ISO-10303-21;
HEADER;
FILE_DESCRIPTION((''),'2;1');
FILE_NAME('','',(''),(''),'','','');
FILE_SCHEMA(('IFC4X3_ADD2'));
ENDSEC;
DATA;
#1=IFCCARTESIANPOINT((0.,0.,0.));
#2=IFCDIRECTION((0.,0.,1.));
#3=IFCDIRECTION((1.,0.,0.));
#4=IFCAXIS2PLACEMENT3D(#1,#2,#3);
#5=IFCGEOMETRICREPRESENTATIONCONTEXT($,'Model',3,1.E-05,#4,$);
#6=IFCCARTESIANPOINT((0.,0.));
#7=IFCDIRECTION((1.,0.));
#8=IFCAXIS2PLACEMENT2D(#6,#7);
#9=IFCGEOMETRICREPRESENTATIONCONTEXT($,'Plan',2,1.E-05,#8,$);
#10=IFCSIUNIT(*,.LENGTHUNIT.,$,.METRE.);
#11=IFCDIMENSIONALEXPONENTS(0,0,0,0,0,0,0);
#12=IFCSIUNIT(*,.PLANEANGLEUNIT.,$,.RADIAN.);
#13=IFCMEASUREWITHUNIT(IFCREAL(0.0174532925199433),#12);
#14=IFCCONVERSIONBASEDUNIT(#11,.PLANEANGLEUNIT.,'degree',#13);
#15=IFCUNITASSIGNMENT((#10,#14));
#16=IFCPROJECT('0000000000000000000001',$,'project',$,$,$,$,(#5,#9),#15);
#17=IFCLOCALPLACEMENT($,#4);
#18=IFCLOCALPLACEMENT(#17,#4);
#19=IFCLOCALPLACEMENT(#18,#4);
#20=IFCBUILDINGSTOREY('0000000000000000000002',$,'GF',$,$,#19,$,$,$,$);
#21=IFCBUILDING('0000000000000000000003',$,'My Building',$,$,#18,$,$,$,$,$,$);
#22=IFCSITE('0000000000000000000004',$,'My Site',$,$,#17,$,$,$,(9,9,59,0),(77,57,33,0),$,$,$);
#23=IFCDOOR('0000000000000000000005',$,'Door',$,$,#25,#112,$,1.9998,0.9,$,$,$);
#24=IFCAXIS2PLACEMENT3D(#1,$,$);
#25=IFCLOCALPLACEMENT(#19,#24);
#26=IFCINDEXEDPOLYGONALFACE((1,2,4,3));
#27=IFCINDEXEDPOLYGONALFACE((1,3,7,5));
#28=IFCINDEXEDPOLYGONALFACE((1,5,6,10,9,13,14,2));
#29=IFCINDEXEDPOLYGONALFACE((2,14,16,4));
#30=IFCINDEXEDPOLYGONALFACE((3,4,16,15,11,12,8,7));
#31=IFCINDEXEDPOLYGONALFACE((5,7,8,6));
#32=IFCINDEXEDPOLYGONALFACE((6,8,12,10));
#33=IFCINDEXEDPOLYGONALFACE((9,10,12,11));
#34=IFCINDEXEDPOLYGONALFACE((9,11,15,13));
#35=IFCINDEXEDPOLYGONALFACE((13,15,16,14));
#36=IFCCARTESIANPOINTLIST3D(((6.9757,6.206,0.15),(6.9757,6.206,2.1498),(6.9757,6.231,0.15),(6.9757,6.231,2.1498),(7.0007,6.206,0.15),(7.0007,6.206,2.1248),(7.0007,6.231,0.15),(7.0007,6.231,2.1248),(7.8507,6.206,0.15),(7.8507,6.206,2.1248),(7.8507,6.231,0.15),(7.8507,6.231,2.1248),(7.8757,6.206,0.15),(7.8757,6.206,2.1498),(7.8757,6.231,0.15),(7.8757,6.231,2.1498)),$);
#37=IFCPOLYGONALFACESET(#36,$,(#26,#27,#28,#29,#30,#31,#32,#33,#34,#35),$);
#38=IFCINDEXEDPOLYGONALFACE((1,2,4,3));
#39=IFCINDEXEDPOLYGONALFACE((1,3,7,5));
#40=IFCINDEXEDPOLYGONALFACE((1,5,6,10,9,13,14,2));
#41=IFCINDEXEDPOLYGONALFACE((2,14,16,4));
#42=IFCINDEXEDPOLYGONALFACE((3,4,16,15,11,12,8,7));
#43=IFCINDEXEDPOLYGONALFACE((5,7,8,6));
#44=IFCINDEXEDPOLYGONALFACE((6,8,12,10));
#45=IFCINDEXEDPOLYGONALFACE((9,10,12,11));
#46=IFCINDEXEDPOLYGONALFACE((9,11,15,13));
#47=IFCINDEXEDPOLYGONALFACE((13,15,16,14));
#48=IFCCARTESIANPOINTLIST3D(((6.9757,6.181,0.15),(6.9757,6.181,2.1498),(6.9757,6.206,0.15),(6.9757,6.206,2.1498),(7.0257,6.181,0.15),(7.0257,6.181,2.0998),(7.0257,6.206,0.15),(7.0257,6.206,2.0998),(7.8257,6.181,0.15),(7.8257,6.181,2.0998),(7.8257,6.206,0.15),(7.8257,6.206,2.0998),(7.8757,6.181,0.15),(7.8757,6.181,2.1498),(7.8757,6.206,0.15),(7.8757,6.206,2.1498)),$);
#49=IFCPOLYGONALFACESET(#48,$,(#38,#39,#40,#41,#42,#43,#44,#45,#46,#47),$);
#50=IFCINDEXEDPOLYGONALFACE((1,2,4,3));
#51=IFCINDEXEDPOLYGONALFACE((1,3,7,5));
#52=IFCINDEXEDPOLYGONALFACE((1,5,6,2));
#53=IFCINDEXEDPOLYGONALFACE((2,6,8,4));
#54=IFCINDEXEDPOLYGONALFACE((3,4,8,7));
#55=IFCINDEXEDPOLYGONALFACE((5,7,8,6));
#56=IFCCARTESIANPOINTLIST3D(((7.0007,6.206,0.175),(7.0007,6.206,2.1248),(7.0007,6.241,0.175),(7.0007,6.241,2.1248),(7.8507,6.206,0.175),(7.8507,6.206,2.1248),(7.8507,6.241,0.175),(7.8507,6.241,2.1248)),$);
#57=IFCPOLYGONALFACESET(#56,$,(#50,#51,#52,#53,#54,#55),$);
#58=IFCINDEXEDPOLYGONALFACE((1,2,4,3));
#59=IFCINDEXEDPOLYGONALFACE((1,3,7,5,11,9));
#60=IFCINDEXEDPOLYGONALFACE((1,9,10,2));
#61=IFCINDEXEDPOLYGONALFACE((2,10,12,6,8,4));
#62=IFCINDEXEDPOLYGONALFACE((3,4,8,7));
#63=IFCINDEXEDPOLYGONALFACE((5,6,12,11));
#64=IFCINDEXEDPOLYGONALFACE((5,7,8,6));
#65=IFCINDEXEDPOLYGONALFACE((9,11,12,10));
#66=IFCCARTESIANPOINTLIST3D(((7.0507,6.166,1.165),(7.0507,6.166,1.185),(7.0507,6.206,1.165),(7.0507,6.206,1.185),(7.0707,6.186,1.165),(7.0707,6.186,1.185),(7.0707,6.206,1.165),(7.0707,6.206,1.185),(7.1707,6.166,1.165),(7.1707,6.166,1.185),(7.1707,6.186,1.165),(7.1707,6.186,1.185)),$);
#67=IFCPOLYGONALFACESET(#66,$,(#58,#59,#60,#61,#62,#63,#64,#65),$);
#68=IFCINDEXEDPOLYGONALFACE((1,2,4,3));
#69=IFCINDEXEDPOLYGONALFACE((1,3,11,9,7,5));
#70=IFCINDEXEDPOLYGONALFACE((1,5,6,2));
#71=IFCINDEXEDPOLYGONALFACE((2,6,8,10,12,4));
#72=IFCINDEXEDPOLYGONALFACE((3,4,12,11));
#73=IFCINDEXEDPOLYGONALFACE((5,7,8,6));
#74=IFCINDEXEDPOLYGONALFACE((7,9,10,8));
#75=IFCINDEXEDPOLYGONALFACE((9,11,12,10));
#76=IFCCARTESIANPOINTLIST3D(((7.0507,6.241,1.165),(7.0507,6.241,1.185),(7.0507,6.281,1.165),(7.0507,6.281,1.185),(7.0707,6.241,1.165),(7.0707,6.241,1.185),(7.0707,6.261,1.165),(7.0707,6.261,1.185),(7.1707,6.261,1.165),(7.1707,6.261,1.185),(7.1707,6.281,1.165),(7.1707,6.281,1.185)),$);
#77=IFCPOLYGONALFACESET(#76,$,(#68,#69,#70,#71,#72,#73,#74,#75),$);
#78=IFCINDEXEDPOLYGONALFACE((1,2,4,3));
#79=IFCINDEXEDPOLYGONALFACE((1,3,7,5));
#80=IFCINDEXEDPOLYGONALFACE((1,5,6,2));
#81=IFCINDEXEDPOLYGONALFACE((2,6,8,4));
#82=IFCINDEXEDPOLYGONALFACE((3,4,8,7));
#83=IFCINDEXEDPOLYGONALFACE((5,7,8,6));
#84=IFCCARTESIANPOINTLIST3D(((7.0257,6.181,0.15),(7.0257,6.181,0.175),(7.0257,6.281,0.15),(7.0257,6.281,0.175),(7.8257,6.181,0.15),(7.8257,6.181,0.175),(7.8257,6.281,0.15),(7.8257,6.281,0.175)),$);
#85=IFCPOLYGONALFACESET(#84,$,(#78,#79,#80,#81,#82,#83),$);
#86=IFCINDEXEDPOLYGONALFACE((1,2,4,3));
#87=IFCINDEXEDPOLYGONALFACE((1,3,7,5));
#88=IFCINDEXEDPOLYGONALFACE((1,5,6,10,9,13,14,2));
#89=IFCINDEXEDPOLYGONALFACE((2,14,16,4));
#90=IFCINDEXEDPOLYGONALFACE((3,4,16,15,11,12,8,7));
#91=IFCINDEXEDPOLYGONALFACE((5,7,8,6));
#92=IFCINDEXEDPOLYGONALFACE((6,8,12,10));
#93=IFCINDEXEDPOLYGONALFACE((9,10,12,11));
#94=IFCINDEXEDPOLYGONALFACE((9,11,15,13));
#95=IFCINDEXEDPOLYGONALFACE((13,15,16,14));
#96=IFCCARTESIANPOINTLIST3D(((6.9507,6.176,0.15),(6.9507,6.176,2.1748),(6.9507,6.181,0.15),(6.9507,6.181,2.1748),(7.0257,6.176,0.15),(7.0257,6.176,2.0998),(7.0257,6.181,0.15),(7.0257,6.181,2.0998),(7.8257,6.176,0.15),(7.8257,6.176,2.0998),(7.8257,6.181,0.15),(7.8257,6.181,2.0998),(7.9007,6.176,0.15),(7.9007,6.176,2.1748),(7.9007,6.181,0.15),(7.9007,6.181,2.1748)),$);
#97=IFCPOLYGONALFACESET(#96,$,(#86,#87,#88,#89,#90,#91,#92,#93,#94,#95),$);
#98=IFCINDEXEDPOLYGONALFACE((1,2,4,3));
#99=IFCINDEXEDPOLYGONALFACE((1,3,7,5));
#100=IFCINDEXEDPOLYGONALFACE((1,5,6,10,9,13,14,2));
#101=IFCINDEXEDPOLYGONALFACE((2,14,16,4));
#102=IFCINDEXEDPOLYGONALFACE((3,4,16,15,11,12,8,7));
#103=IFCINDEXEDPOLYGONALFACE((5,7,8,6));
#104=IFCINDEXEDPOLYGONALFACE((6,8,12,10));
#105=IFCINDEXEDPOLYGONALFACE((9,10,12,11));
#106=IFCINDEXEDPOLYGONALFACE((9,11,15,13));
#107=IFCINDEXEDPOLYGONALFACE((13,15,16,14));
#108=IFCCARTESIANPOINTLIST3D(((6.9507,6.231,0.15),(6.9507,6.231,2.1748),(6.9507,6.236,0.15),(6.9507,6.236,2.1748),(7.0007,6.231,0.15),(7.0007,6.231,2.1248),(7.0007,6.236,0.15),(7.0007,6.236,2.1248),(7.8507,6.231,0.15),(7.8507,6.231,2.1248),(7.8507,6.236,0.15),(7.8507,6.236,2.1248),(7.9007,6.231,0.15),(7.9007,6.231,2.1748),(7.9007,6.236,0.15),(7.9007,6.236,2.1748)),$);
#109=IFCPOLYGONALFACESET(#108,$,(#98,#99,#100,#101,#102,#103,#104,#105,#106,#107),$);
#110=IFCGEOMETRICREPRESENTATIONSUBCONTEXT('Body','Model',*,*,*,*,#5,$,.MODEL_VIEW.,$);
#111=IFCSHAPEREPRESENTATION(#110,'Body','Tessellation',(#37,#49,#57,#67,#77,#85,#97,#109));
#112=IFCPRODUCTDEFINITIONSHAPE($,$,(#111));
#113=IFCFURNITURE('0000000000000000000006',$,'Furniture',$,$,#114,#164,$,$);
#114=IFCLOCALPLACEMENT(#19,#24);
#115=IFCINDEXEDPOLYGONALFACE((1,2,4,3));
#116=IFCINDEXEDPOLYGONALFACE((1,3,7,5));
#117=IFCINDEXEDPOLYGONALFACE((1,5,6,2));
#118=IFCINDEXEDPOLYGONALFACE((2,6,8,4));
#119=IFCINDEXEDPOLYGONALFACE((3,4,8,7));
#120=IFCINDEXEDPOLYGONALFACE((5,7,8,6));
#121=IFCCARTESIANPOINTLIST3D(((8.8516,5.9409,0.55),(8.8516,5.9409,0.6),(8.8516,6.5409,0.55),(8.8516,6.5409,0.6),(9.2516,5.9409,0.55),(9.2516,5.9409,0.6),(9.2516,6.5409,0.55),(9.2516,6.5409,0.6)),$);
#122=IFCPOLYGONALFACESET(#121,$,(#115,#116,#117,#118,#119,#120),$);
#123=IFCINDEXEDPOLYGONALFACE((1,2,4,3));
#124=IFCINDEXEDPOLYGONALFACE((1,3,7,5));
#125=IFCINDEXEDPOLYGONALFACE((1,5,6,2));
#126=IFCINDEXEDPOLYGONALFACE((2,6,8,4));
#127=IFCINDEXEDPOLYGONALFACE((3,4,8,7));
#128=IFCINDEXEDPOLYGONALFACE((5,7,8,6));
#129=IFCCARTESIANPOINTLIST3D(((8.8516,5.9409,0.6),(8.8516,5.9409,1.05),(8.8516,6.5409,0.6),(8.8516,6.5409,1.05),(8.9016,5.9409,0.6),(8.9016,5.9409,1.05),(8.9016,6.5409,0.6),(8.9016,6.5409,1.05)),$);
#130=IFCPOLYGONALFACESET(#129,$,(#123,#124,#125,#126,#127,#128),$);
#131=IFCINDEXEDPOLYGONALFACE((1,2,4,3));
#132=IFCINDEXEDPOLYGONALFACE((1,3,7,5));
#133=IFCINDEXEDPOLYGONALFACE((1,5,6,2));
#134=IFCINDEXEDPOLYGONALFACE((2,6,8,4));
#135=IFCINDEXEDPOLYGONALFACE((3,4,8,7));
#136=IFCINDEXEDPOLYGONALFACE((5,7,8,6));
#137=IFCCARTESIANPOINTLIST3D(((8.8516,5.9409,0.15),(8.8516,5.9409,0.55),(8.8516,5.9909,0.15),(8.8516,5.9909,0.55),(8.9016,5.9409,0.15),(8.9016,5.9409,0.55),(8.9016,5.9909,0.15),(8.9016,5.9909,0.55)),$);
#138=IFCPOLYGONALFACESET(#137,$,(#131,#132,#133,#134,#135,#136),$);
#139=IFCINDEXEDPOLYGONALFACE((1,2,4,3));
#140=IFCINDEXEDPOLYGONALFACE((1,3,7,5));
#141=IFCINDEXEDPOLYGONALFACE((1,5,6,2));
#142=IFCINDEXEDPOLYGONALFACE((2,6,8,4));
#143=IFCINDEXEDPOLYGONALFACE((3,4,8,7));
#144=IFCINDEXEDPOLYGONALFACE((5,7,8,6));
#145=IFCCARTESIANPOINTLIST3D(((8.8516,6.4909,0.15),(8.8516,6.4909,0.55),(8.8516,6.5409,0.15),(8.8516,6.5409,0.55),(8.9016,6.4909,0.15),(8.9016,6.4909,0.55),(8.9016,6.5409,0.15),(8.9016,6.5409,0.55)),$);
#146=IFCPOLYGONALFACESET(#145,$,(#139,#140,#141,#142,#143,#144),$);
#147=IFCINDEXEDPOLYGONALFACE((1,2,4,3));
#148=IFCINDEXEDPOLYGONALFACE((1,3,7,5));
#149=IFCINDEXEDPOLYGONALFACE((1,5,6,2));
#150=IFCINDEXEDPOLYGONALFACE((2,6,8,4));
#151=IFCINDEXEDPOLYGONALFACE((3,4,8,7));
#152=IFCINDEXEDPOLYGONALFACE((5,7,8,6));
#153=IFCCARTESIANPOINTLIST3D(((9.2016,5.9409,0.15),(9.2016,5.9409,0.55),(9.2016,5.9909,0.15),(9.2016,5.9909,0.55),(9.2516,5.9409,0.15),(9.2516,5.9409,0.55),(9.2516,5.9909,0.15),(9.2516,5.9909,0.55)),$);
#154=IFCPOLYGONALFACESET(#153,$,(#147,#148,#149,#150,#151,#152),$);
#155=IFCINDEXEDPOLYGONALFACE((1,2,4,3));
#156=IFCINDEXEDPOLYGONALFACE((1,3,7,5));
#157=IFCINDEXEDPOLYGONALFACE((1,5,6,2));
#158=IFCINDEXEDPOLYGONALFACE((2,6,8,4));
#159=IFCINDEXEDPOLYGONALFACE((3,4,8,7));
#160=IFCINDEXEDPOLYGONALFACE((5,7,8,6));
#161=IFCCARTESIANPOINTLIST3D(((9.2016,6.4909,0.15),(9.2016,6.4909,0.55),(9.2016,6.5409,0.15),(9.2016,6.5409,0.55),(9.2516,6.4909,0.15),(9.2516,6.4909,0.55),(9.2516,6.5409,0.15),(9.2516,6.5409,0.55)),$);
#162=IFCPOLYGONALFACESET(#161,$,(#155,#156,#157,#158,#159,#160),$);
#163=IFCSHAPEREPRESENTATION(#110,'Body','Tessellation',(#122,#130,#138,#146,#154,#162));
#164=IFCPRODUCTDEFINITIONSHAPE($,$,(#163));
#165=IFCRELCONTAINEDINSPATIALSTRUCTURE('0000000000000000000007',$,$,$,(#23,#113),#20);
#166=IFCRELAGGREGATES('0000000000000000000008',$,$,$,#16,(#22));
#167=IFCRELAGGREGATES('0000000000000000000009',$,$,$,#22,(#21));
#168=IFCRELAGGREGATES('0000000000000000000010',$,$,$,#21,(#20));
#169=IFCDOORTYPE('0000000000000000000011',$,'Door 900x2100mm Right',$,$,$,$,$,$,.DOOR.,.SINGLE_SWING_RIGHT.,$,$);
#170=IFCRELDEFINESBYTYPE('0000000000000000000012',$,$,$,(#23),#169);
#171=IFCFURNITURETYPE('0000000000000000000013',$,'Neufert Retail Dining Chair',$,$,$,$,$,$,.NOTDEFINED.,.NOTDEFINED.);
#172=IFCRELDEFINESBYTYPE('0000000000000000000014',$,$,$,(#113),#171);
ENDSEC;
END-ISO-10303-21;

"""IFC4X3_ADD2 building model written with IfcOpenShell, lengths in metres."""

from ifc_helpers import new_model, entity, si_unit, converted_unit, frame, origin_with_axes, origin_2d_with_axis, place, context, subcontext, project, spatial, line, indexed_curve, outline, extrude, shape, source, transform, mapped, type_object, type_shapes, element, save


model = new_model("IFC4X3_ADD2")

# Units and contexts
model_context = context("Model", 3, precision=1e-05, world=origin_with_axes())
plan_context = context("Plan", 2, precision=1e-05, world=origin_2d_with_axis())
body_context_1 = subcontext(model_context, "Body", "Model", "MODEL_VIEW")
body_context_2 = subcontext(plan_context, "Body", "Plan", "PLAN_VIEW")
ifc_project = project(units=[si_unit("LENGTHUNIT", "METRE"), converted_unit("PLANEANGLEUNIT", "degree", entity("IfcReal", 0.0174532925199433), si_unit("PLANEANGLEUNIT", "RADIAN"), dimensions=[0, 0, 0, 0, 0, 0, 0])], contexts=[model_context, plan_context])

# Site, building, storey
site_placement = place(None, origin_with_axes())
site = spatial("IfcSite", under=ifc_project, at=site_placement, Name="My Site", RefLatitude=(9, 9, 59, 0), RefLongitude=(77, 57, 33, 0))
building_placement = place(site_placement, origin_with_axes())
building = spatial("IfcBuilding", under=site, at=building_placement, Name="My Building")
storey_placement = place(building_placement, origin_with_axes())
storey = spatial("IfcBuildingStorey", under=building, at=storey_placement, Name="GF")

# Shared definitions
door_type = type_object("IfcDoorType", Name="Door 900x2100mm Right", OperationType="SINGLE_SWING_RIGHT", PredefinedType="DOOR")
shared_shape_1 = source(origin_with_axes(), body_context_1, "Body", "SweptSolid", [
    extrude(outline(indexed_curve([(0.0, 0.0), (0.0, 1.9998), (0.9, 1.9998), (0.9, 0.0), (0.875, 0.0), (0.875, 1.9748), (0.025, 1.9748), (0.025, 0.0)], segments=[line(1, 2, 3, 4, 5, 6, 7, 8, 1)])), frame((0.0, 0.025, 0.0), z_axis=(0.0, -1.0, 0.0), x_axis=(1.0, 0.0, 0.0)), (0.0, 0.0, -1.0), 0.025),
    extrude(outline(indexed_curve([(0.0, 0.0), (0.0, 1.9998), (0.9, 1.9998), (0.9, 0.0), (0.85, 0.0), (0.85, 1.9498), (0.05, 1.9498), (0.05, 0.0)], segments=[line(1, 2, 3, 4, 5, 6, 7, 8, 1)])), frame((0.0, 0.0, 0.0), z_axis=(0.0, -1.0, 0.0), x_axis=(1.0, 0.0, 0.0)), (0.0, 0.0, -1.0), 0.025),
    extrude(outline(indexed_curve([(0.0, 0.0), (0.85, 0.0), (0.85, 0.035), (0.0, 0.035)], segments=[line(1, 2, 3, 4, 1)])), frame((0.025, 0.025, 0.025), z_axis=(0.0, 0.0, 1.0), x_axis=(1.0, 0.0, 0.0)), (0.0, 0.0, 1.0), 1.9498),
    extrude(outline(indexed_curve([(0.0, 0.0), (0.0, -0.04), (0.12, -0.04), (0.12, -0.02), (0.02, -0.02), (0.02, 0.0)], segments=[line(1, 2, 3, 4, 5, 6, 1)])), frame((0.075, 0.025, 1.015), z_axis=(0.0, 0.0, 1.0), x_axis=(1.0, 0.0, 0.0)), (0.0, 0.0, 1.0), 0.02),
    extrude(outline(indexed_curve([(0.0, 0.0), (0.0, 0.04), (0.12, 0.04), (0.12, 0.02), (0.02, 0.02), (0.02, 0.0)], segments=[line(1, 2, 3, 4, 5, 6, 1)])), frame((0.075, 0.06, 1.015), z_axis=(0.0, 0.0, 1.0), x_axis=(1.0, 0.0, 0.0)), (0.0, 0.0, 1.0), 0.02),
    extrude(outline(indexed_curve([(0.0, 0.0), (0.8, 0.0), (0.8, 0.1), (0.0, 0.1)], segments=[line(1, 2, 3, 4, 1)])), frame((0.05, 0.0, 0.0), z_axis=(0.0, 0.0, 1.0), x_axis=(1.0, 0.0, 0.0)), (0.0, 0.0, 1.0), 0.025),
    extrude(outline(indexed_curve([(0.0, 0.0), (0.0, 2.0248), (0.95, 2.0248), (0.95, 0.0), (0.875, 0.0), (0.875, 1.9498), (0.075, 1.9498), (0.075, 0.0)], segments=[line(1, 2, 3, 4, 5, 6, 7, 8, 1)])), frame((-0.025, -0.005, 0.0), z_axis=(0.0, -1.0, 0.0), x_axis=(1.0, 0.0, 0.0)), (0.0, 0.0, -1.0), 0.005),
    extrude(outline(indexed_curve([(0.0, 0.0), (0.0, 2.0248), (0.95, 2.0248), (0.95, 0.0), (0.9, 0.0), (0.9, 1.9748), (0.05, 1.9748), (0.05, 0.0)], segments=[line(1, 2, 3, 4, 5, 6, 7, 8, 1)])), frame((-0.025, 0.05, 0.0), z_axis=(0.0, -1.0, 0.0), x_axis=(1.0, 0.0, 0.0)), (0.0, 0.0, -1.0), 0.005),
])
shared_shape_2 = source(origin_with_axes(), body_context_2, "Body", "Curve2D", [
    entity("IfcIndexedPolyCurve", entity("IfcCartesianPointList2D", [[0.0, 0.0], [0.0, 0.05], [0.025, 0.05], [0.025, 0.025], [0.05, 0.025], [0.05, 0.0]]), [entity("IfcLineIndex", [1, 2, 3, 4, 5, 6, 1])]),
    entity("IfcIndexedPolyCurve", entity("IfcCartesianPointList2D", [[0.9, 0.0], [0.9, 0.05], [0.875, 0.05], [0.875, 0.025], [0.85, 0.025], [0.85, 0.0]]), [entity("IfcLineIndex", [1, 2, 3, 4, 5, 6, 1])]),
    entity("IfcTrimmedCurve", entity("IfcEllipse", entity("IfcAxis2Placement2D", entity("IfcCartesianPoint", [0.84, 0.05]), entity("IfcDirection", [1.0, 0.0])), 0.815, 0.85), [entity("IfcCartesianPoint", [0.84, 0.9])], [entity("IfcCartesianPoint", [0.025, 0.05])], True, "CARTESIAN"),
    entity("IfcIndexedPolyCurve", entity("IfcCartesianPointList2D", [[0.875, 0.05], [0.84, 0.05], [0.84, 0.9], [0.875, 0.9]]), [entity("IfcLineIndex", [1, 2, 3, 4, 1])]),
])
type_shapes(door_type, [shared_shape_1, shared_shape_2])

# Door
door_1_placement = place(storey_placement, frame((6.9757, 6.181, 0.15), z_axis=(0.0, 0.0, 1.0), x_axis=(1.0, -0.000001, 0.0)))
element("IfcDoor", 1, at=door_1_placement, inside=storey, type_object=door_type, Name="Door", OverallHeight=1.9998, OverallWidth=0.9, shapes=[
    shape(body_context_1, "Body", "MappedRepresentation", [mapped(shared_shape_1, transform((0.0, 0.0, 0.0), x_axis=(1.0, 0.0, 0.0), y_axis=(0.0, 1.0, 0.0), z_axis=(0.0, 0.0, 1.0), scale=1.0))]),
    shape(body_context_2, "Body", "MappedRepresentation", [mapped(shared_shape_2, transform((0.0, 0.0, 0.0), x_axis=(1.0, 0.0, 0.0), y_axis=(0.0, 1.0, 0.0), z_axis=(0.0, 0.0, 1.0), scale=1.0))]),
])

# Furniture
furniture_type_1 = type_object("IfcFurnitureType", Name="Neufert Retail Dining Chair", AssemblyPlace="NOTDEFINED", PredefinedType="NOTDEFINED")
shared_shape_3 = source(origin_with_axes(), body_context_1, "Body", "SweptSolid", [
    extrude(outline(indexed_curve([(-0.3, 0.0), (0.3, 0.0), (0.3, -0.4), (-0.3, -0.4)], segments=[line(1, 2, 3, 4, 1)])), frame((0.0, 0.0, 0.45), z_axis=(0.0, 0.0, 1.0), x_axis=(1.0, 0.0, 0.0)), (0.0, 0.0, -1.0), 0.05),
    extrude(outline(indexed_curve([(-0.3, 0.0), (0.3, 0.0), (0.3, -0.05), (-0.3, -0.05)], segments=[line(1, 2, 3, 4, 1)])), frame((0.0, 0.0, 0.9), z_axis=(0.0, 0.0, 1.0), x_axis=(1.0, 0.0, 0.0)), (0.0, 0.0, -1.0), 0.45),
    extrude(outline(indexed_curve([(-0.3, 0.0), (-0.25, 0.0), (-0.25, -0.05), (-0.3, -0.05)], segments=[line(1, 2, 3, 4, 1)])), origin_with_axes(), (0.0, 0.0, 1.0), 0.4),
    extrude(outline(indexed_curve([(0.3, 0.0), (0.25, 0.0), (0.25, -0.05), (0.3, -0.05)], segments=[line(1, 2, 3, 4, 1)])), origin_with_axes(), (0.0, 0.0, 1.0), 0.4),
    extrude(outline(indexed_curve([(-0.3, -0.4), (-0.25, -0.4), (-0.25, -0.35), (-0.3, -0.35)], segments=[line(1, 2, 3, 4, 1)])), origin_with_axes(), (0.0, 0.0, 1.0), 0.4),
    extrude(outline(indexed_curve([(0.3, -0.4), (0.25, -0.4), (0.25, -0.35), (0.3, -0.35)], segments=[line(1, 2, 3, 4, 1)])), origin_with_axes(), (0.0, 0.0, 1.0), 0.4),
])
shared_shape_4 = source(origin_with_axes(), body_context_2, "Body", "Curve2D", [
    entity("IfcIndexedPolyCurve", entity("IfcCartesianPointList2D", [[-0.3, -0.4], [0.3, -0.4]])),
    entity("IfcIndexedPolyCurve", entity("IfcCartesianPointList2D", [[-0.3, -0.4], [-0.3, -0.3], [-0.2121, -0.0879], [0.0, 0.0], [0.2121, -0.0879], [0.3, -0.3], [0.3, -0.4]]), [entity("IfcLineIndex", [1, 2]), entity("IfcArcIndex", [2, 3, 4]), entity("IfcArcIndex", [4, 5, 6]), entity("IfcLineIndex", [6, 7])]),
    entity("IfcIndexedPolyCurve", entity("IfcCartesianPointList2D", [[-0.26, -0.4], [-0.26, -0.3], [-0.1838, -0.1162], [0.0, -0.04], [0.1838, -0.1162], [0.26, -0.3], [0.26, -0.4]]), [entity("IfcLineIndex", [1, 2]), entity("IfcArcIndex", [2, 3, 4]), entity("IfcArcIndex", [4, 5, 6]), entity("IfcLineIndex", [6, 7])]),
])
type_shapes(furniture_type_1, [shared_shape_3, shared_shape_4])
furniture_1_placement = place(storey_placement, frame((8.8516, 6.2409, 0.15), z_axis=(0.0, 0.0, 1.0), x_axis=(0.000002, 1.0, 0.0)))
element("IfcFurniture", 2, at=furniture_1_placement, inside=storey, type_object=furniture_type_1, Name="Furniture", shapes=[
    shape(body_context_1, "Body", "MappedRepresentation", [mapped(shared_shape_3, transform((0.0, 0.0, 0.0), x_axis=(1.0, 0.0, 0.0), y_axis=(0.0, 1.0, 0.0), z_axis=(0.0, 0.0, 1.0), scale=1.0))]),
    shape(body_context_2, "Body", "MappedRepresentation", [mapped(shared_shape_4, transform((0.0, 0.0, 0.0), x_axis=(1.0, 0.0, 0.0), y_axis=(0.0, 1.0, 0.0), z_axis=(0.0, 0.0, 1.0), scale=1.0))]),
])

save(model, "model.ifc")
